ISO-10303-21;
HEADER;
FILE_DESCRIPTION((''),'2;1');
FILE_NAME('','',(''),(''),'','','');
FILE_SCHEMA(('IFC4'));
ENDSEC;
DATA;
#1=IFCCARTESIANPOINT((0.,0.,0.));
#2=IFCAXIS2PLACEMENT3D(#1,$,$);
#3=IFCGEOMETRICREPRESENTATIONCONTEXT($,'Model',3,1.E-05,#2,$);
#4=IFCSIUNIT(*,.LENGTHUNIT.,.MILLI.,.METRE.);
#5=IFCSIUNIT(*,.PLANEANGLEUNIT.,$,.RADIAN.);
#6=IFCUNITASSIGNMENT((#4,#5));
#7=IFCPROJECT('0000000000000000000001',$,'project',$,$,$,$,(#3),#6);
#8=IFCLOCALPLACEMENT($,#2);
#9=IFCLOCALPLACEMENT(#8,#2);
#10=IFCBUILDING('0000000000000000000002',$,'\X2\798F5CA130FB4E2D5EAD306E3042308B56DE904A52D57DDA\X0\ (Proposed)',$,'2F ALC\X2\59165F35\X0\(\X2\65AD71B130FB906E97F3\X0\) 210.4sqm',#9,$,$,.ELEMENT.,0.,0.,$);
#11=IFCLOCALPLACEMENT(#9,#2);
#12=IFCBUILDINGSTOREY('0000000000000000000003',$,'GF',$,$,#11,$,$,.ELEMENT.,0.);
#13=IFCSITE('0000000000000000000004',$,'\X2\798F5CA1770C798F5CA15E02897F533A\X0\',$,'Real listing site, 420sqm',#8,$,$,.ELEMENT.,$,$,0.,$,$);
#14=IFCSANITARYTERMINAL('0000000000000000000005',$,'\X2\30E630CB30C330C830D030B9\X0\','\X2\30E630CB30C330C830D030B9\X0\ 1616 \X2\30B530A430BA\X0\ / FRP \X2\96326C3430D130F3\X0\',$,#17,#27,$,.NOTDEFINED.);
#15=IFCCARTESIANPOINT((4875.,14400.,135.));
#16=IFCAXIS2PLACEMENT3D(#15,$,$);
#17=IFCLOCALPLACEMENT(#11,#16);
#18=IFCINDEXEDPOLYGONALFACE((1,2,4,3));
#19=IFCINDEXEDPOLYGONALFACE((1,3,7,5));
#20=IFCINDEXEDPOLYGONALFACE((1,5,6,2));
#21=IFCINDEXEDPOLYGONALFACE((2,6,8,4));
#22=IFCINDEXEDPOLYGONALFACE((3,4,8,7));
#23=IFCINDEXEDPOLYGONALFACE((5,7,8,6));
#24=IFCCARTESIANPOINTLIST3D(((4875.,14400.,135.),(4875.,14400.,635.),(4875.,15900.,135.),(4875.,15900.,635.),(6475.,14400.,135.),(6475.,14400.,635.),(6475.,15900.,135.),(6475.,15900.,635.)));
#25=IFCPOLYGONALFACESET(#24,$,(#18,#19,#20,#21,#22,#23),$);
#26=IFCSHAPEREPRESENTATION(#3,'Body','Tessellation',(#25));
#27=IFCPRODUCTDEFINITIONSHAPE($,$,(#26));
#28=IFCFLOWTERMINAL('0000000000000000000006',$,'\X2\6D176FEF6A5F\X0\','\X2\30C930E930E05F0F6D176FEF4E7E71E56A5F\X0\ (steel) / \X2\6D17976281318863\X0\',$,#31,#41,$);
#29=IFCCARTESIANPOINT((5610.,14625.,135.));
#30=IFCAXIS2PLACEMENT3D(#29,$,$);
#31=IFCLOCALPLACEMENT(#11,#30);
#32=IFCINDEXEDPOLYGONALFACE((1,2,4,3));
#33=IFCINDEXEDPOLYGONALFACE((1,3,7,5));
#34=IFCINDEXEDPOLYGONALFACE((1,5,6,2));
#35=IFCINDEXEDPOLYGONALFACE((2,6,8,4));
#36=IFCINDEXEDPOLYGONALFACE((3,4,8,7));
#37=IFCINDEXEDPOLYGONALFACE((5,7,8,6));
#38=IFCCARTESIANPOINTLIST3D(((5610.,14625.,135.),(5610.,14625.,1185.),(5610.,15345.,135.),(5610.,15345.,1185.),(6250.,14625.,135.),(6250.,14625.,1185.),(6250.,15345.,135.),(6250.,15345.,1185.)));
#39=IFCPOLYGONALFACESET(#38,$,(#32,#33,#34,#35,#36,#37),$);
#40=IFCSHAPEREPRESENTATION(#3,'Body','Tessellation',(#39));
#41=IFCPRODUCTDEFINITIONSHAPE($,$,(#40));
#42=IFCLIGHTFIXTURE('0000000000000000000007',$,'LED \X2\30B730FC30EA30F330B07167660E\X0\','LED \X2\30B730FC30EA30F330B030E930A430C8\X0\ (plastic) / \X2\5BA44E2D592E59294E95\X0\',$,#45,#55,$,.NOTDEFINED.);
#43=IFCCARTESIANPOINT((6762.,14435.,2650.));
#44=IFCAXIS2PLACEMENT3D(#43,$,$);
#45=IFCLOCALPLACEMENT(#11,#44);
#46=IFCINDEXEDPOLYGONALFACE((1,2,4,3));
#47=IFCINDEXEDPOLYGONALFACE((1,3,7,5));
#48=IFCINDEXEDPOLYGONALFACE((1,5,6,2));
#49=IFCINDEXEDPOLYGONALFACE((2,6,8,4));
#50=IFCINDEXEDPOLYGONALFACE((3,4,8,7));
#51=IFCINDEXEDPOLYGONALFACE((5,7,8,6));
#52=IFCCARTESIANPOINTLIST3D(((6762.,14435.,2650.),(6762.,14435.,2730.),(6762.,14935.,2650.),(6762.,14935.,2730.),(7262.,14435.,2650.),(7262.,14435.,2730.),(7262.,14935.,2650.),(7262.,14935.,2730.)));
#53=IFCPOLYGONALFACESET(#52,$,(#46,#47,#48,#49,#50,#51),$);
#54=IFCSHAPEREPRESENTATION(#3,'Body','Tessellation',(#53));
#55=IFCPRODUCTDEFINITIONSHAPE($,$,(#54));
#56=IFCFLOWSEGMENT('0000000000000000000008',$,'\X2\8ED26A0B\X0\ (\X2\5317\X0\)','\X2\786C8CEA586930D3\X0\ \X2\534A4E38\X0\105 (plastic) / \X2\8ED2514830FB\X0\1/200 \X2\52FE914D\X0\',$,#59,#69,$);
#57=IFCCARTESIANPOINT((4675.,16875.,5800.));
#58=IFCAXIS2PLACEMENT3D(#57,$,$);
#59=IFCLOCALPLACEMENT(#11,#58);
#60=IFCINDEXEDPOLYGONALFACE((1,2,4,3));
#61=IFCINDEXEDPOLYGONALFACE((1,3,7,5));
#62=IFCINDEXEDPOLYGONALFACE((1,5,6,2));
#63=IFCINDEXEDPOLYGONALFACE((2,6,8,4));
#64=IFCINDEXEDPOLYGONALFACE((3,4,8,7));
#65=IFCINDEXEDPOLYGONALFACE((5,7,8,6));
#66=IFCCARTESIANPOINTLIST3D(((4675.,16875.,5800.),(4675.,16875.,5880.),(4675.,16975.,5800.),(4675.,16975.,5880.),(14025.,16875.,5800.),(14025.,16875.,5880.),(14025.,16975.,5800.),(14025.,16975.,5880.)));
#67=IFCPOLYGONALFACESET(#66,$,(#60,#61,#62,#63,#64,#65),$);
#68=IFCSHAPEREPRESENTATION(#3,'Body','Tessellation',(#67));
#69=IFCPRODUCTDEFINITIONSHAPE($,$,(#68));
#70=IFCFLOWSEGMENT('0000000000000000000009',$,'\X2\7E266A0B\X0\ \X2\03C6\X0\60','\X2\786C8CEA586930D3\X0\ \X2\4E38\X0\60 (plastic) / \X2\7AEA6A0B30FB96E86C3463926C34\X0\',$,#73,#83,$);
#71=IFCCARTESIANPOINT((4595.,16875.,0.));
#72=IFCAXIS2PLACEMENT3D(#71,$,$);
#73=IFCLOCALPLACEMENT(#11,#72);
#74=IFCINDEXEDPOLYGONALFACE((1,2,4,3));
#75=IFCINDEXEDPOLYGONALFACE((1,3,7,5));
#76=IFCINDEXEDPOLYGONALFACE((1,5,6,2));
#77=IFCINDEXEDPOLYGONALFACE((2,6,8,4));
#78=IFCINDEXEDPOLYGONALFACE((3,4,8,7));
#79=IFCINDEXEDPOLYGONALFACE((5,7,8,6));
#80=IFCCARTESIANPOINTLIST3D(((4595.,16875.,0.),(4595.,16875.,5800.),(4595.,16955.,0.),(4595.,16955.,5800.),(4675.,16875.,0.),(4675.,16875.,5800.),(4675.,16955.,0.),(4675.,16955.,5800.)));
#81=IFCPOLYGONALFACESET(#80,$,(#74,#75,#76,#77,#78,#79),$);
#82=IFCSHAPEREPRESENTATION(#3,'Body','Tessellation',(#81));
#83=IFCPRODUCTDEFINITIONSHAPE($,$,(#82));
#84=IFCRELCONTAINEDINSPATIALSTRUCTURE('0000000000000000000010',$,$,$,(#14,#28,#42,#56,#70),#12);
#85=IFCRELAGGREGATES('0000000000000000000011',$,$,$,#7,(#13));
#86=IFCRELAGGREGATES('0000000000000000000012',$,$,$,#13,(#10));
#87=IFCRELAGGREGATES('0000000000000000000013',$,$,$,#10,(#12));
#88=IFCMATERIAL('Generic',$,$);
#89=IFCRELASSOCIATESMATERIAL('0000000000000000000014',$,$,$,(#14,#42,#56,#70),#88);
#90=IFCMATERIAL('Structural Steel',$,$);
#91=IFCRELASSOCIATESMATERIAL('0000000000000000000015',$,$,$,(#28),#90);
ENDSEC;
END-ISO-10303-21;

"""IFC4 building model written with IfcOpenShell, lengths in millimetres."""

from ifc_helpers import new_model, si_unit, frame, frame_2d, origin, place, context, project, spatial, rectangle, extrude, material, element, save


model = new_model("IFC4")

# Units and contexts
model_context = context("Model", 3, precision=1e-05, world=origin())
ifc_project = project(units=[si_unit("LENGTHUNIT", "METRE", prefix="MILLI"), si_unit("PLANEANGLEUNIT", "RADIAN")], contexts=[model_context])

# Site, building, storey
site_placement = place(None, origin())
site = spatial("IfcSite", under=ifc_project, at=site_placement, Name="福岡県福岡市西区", ObjectType="Real listing site, 420sqm", CompositionType="ELEMENT", RefElevation=0.0)
building_placement = place(site_placement, origin())
building = spatial("IfcBuilding", under=site, at=building_placement, Name="福岡・中庭のある回遊動線 (Proposed)", ObjectType="2F ALC外張(断熱・遮音) 210.4sqm", CompositionType="ELEMENT", ElevationOfRefHeight=0.0, ElevationOfTerrain=0.0)
storey_placement = place(building_placement, origin())
storey = spatial("IfcBuildingStorey", under=building, at=storey_placement, Name="GF", CompositionType="ELEMENT", Elevation=0.0)

# Sanitary terminal
ifc_material_1 = material(Name="Generic")
sanitary_terminal_placement = place(storey_placement, frame((4875.0, 14400.0, 135.0)))
element("IfcSanitaryTerminal", 1, at=sanitary_terminal_placement, inside=storey, material=ifc_material_1, Name="ユニットバス", Description="ユニットバス 1616 サイズ / FRP 防水パン", PredefinedType="NOTDEFINED", context=model_context, shape_type="SweptSolid", body=[
    extrude(rectangle(XDim=1600.0, YDim=1500.0, at=frame_2d((800.0, 750.0))), frame((4875.0, 14400.0, 135.0)), (0.0, 0.0, 1.0), 500.0),
])

# Flow terminal
ifc_material_2 = material(Name="Structural Steel")
flow_terminal_placement = place(storey_placement, frame((5610.0, 14625.0, 135.0)))
element("IfcFlowTerminal", 2, at=flow_terminal_placement, inside=storey, material=ifc_material_2, Name="洗濯機", Description="ドラム式洗濯乾燥機 (steel) / 洗面脱衣", context=model_context, shape_type="SweptSolid", body=[
    extrude(rectangle(XDim=640.0, YDim=720.0, at=frame_2d((320.0, 360.0))), frame((5610.0, 14625.0, 135.0)), (0.0, 0.0, 1.0), 1050.0),
])

# Light fixture
light_fixture_placement = place(storey_placement, frame((6762.0, 14435.0, 2650.0)))
element("IfcLightFixture", 3, at=light_fixture_placement, inside=storey, material=ifc_material_1, Name="LED シーリング照明", Description="LED シーリングライト (plastic) / 室中央天井", PredefinedType="NOTDEFINED", context=model_context, shape_type="SweptSolid", body=[
    extrude(rectangle(XDim=500.0, YDim=500.0, at=frame_2d((250.0, 250.0))), frame((6762.0, 14435.0, 2650.0)), (0.0, 0.0, 1.0), 80.0),
])

# Flow segments
flow_segment_1_placement = place(storey_placement, frame((4675.0, 16875.0, 5800.0)))
element("IfcFlowSegment", 4, at=flow_segment_1_placement, inside=storey, material=ifc_material_1, Name="軒樋 (北)", Description="硬質塩ビ 半丸105 (plastic) / 軒先・1/200 勾配", context=model_context, shape_type="SweptSolid", body=[
    extrude(rectangle(XDim=9350.0, YDim=100.0, at=frame_2d((4675.0, 50.0))), frame((4675.0, 16875.0, 5800.0)), (0.0, 0.0, 1.0), 80.0),
])
flow_segment_2_placement = place(storey_placement, frame((4595.0, 16875.0, 0.0)))
element("IfcFlowSegment", 5, at=flow_segment_2_placement, inside=storey, material=ifc_material_1, Name="縦樋 φ60", Description="硬質塩ビ 丸60 (plastic) / 竪樋・雨水排水", context=model_context, shape_type="SweptSolid", body=[
    extrude(rectangle(XDim=80.0, YDim=80.0, at=frame_2d((40.0, 40.0))), frame((4595.0, 16875.0, 0.0)), (0.0, 0.0, 1.0), 5800.0),
])

save(model, "model.ifc")
